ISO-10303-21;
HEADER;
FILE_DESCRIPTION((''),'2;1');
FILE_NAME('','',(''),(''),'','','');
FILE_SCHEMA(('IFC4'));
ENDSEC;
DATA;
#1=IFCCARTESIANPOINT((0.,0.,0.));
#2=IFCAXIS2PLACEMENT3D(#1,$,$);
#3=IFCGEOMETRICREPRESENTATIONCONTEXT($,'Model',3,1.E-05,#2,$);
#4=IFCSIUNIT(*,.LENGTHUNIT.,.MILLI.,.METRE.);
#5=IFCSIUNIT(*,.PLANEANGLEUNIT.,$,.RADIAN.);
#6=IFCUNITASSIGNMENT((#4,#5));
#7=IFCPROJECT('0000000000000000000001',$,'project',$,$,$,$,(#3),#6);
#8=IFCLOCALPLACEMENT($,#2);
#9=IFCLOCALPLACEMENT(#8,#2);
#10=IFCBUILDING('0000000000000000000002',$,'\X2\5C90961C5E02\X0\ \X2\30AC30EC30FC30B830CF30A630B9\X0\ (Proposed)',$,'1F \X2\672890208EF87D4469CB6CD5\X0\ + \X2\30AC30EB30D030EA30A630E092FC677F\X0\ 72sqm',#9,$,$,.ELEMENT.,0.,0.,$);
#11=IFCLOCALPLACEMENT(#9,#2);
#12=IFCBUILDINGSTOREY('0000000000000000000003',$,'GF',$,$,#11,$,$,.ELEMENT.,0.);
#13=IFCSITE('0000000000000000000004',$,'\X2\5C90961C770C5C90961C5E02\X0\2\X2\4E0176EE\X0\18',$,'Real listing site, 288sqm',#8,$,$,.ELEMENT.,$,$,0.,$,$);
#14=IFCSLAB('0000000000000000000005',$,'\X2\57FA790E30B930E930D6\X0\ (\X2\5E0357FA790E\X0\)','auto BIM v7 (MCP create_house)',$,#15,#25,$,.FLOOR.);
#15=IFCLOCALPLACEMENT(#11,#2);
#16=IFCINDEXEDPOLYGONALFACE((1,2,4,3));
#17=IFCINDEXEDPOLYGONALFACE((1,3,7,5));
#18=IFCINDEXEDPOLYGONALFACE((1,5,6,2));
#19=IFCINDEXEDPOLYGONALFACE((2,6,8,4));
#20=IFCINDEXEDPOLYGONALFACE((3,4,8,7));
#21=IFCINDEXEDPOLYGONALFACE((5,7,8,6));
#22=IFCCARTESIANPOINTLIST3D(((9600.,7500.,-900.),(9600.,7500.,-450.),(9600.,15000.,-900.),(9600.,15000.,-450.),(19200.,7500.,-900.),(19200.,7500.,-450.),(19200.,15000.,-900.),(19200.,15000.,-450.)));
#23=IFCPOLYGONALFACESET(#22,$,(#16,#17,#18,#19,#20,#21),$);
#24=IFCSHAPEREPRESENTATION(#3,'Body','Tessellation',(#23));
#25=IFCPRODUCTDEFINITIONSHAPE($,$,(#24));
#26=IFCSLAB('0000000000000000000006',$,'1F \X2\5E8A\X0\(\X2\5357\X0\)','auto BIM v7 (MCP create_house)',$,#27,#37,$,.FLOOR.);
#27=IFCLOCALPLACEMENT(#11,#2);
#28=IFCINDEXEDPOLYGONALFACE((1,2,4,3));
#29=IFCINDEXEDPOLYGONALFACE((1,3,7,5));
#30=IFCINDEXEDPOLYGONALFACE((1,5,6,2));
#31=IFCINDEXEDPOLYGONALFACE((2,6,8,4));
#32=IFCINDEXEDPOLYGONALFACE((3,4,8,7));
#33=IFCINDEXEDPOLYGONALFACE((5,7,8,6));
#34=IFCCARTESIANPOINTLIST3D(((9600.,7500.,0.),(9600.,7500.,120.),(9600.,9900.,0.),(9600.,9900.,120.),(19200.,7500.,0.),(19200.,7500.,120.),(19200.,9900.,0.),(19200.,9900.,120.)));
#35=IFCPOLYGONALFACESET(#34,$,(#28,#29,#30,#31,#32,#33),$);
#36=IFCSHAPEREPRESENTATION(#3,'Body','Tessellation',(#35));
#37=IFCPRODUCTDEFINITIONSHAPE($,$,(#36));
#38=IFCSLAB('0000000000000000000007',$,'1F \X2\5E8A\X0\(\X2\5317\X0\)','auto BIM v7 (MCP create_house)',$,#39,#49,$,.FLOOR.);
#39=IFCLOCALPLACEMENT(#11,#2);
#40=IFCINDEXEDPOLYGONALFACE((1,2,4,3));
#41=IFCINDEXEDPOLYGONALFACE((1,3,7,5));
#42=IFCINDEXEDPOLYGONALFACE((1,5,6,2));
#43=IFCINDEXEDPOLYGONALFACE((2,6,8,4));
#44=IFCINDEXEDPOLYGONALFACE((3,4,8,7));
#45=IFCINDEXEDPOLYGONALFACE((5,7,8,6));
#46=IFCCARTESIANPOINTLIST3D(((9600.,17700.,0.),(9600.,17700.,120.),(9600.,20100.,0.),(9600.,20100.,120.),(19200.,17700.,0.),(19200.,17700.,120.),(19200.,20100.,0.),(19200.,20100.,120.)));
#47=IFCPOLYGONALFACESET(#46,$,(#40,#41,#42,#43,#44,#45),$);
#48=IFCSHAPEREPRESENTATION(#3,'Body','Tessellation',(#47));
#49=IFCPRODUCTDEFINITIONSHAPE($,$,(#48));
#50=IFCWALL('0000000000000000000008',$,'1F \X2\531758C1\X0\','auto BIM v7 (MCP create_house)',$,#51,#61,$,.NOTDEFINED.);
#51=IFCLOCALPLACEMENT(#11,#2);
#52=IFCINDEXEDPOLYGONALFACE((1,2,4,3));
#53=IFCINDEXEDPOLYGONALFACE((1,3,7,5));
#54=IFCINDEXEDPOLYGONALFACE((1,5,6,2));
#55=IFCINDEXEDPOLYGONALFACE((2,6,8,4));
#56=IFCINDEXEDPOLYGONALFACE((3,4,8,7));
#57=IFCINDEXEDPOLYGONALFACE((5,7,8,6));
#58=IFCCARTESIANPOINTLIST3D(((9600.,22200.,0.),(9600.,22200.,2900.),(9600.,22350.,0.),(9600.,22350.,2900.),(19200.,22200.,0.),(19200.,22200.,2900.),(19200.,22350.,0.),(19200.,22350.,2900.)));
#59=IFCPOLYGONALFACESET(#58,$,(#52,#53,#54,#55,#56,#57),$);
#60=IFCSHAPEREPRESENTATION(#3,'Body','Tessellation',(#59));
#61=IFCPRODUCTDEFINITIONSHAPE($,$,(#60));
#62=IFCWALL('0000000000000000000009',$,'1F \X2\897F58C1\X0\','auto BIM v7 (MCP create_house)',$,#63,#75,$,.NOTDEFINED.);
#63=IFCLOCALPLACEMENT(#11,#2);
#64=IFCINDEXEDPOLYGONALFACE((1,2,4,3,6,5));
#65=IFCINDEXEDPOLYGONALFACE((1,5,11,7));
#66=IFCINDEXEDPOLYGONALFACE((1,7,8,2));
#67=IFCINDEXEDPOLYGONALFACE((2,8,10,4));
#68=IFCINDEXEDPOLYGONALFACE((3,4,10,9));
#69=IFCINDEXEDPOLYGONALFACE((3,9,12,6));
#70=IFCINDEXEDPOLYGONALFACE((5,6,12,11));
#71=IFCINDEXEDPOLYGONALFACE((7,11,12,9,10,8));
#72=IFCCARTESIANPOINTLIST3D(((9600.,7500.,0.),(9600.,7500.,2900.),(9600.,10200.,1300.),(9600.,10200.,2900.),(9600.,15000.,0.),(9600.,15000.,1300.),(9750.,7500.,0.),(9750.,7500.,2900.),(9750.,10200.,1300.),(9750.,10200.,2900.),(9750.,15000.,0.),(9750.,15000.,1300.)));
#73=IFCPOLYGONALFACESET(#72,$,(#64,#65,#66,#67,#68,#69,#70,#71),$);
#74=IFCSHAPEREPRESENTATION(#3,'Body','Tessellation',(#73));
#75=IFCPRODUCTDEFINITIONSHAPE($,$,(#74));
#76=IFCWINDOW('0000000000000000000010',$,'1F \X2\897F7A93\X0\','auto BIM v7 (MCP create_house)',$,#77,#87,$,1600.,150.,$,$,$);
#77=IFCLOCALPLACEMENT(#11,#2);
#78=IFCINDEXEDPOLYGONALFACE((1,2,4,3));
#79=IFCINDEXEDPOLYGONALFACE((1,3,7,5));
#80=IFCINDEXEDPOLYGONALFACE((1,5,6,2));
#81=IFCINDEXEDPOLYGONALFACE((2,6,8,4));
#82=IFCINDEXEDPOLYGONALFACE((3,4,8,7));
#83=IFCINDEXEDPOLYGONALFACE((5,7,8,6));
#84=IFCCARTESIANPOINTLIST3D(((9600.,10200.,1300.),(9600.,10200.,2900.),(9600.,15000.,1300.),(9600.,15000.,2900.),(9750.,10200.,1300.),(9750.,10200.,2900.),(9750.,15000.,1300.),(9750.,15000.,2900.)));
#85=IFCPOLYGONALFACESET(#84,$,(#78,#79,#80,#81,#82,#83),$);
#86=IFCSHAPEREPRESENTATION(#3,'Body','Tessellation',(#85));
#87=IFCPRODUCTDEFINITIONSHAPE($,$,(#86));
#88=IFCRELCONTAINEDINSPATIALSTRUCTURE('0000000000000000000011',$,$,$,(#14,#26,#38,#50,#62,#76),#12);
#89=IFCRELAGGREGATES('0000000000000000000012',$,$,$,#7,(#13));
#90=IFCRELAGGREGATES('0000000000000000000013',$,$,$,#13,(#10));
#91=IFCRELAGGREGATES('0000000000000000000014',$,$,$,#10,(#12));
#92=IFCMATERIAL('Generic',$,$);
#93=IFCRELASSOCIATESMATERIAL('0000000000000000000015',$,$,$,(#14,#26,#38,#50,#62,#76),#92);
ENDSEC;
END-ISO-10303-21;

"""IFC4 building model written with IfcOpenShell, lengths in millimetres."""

from ifc_helpers import new_model, si_unit, frame, frame_2d, origin, place, context, project, spatial, rectangle, extrude, material, element, fill, save


model = new_model("IFC4")

# Units and contexts
model_context = context("Model", 3, precision=1e-05, world=origin())
ifc_project = project(units=[si_unit("LENGTHUNIT", "METRE", prefix="MILLI"), si_unit("PLANEANGLEUNIT", "RADIAN")], contexts=[model_context])

# Site, building, storey
site_placement = place(None, origin())
site = spatial("IfcSite", under=ifc_project, at=site_placement, Name="岐阜県岐阜市2丁目18", ObjectType="Real listing site, 288sqm", CompositionType="ELEMENT", RefElevation=0.0)
building_placement = place(site_placement, origin())
building = spatial("IfcBuilding", under=site, at=building_placement, Name="岐阜市 ガレージハウス (Proposed)", ObjectType="1F 木造軸組構法 + ガルバリウム鋼板 72sqm", CompositionType="ELEMENT", ElevationOfRefHeight=0.0, ElevationOfTerrain=0.0)
storey_placement = place(building_placement, origin())
storey = spatial("IfcBuildingStorey", under=building, at=storey_placement, Name="GF", CompositionType="ELEMENT", Elevation=0.0)

# Slabs
ifc_material = material(Name="Generic")
slab_1_placement = place(storey_placement, frame((4800.0, 3750.0, -450.0)))
element("IfcSlab", 1, at=slab_1_placement, inside=storey, material=ifc_material, Name="基礎スラブ (布基礎)", Description="auto BIM v7 (MCP create_house)", PredefinedType="FLOOR", context=model_context, shape_type="SweptSolid", body=[
    extrude(rectangle(XDim=9600.0, YDim=7500.0, at=frame_2d((4800.0, 3750.0))), frame((4800.0, 3750.0, -450.0)), (0.0, 0.0, 1.0), 450.0),
])
slab_2_placement = place(storey_placement, frame((4800.0, 3750.0, 0.0)))
element("IfcSlab", 2, at=slab_2_placement, inside=storey, material=ifc_material, Name="1F 床(南)", Description="auto BIM v7 (MCP create_house)", PredefinedType="FLOOR", context=model_context, shape_type="SweptSolid", body=[
    extrude(rectangle(XDim=9600.0, YDim=2400.0, at=frame_2d((4800.0, 1200.0))), frame((4800.0, 3750.0, 0.0)), (0.0, 0.0, 1.0), 120.0),
])
slab_3_placement = place(storey_placement, frame((4800.0, 8850.0, 0.0)))
element("IfcSlab", 3, at=slab_3_placement, inside=storey, material=ifc_material, Name="1F 床(北)", Description="auto BIM v7 (MCP create_house)", PredefinedType="FLOOR", context=model_context, shape_type="SweptSolid", body=[
    extrude(rectangle(XDim=9600.0, YDim=2400.0, at=frame_2d((4800.0, 1200.0))), frame((4800.0, 8850.0, 0.0)), (0.0, 0.0, 1.0), 120.0),
])

# Wall
wall_1_placement = place(storey_placement, frame((4800.0, 11100.0, 0.0)))
element("IfcWall", 4, at=wall_1_placement, inside=storey, material=ifc_material, Name="1F 北壁", Description="auto BIM v7 (MCP create_house)", PredefinedType="NOTDEFINED", context=model_context, shape_type="SweptSolid", body=[
    extrude(rectangle(XDim=9600.0, YDim=150.0, at=frame_2d((4800.0, 75.0))), frame((4800.0, 11100.0, 0.0)), (0.0, 0.0, 1.0), 2900.0),
])

# Wall, opening, window
wall_2_placement = place(storey_placement, frame((4800.0, 3750.0, 0.0)))
wall_2 = element("IfcWall", 5, at=wall_2_placement, inside=storey, material=ifc_material, Name="1F 西壁", Description="auto BIM v7 (MCP create_house)", PredefinedType="NOTDEFINED", context=model_context, shape_type="SweptSolid", body=[
    extrude(rectangle(XDim=150.0, YDim=7500.0, at=frame_2d((75.0, 3750.0))), frame((4800.0, 3750.0, 0.0)), (0.0, 0.0, 1.0), 2900.0),
])
opening_1_placement = place(storey_placement, frame((4800.0, 5100.0, 650.0)))
opening_1 = element("IfcOpeningElement", 6, at=opening_1_placement, cuts=wall_2, PredefinedType="NOTDEFINED", context=model_context, shape_type="SweptSolid", body=[
    extrude(rectangle(XDim=150.0, YDim=4800.0, at=frame_2d((75.0, 2400.0))), frame((4800.0, 5100.0, 650.0)), (0.0, 0.0, 1.0), 1600.0),
])
window_1_placement = place(storey_placement, frame((4800.0, 5100.0, 650.0)))
window_1 = element("IfcWindow", 7, at=window_1_placement, inside=storey, material=ifc_material, Name="1F 西窓", Description="auto BIM v7 (MCP create_house)", OverallHeight=1600.0, OverallWidth=150.0, context=model_context, shape_type="SweptSolid", body=[
    extrude(rectangle(XDim=150.0, YDim=4800.0, at=frame_2d((75.0, 2400.0))), frame((4800.0, 5100.0, 650.0)), (0.0, 0.0, 1.0), 1600.0),
])
fill(opening_1, window_1)

save(model, "model.ifc")
